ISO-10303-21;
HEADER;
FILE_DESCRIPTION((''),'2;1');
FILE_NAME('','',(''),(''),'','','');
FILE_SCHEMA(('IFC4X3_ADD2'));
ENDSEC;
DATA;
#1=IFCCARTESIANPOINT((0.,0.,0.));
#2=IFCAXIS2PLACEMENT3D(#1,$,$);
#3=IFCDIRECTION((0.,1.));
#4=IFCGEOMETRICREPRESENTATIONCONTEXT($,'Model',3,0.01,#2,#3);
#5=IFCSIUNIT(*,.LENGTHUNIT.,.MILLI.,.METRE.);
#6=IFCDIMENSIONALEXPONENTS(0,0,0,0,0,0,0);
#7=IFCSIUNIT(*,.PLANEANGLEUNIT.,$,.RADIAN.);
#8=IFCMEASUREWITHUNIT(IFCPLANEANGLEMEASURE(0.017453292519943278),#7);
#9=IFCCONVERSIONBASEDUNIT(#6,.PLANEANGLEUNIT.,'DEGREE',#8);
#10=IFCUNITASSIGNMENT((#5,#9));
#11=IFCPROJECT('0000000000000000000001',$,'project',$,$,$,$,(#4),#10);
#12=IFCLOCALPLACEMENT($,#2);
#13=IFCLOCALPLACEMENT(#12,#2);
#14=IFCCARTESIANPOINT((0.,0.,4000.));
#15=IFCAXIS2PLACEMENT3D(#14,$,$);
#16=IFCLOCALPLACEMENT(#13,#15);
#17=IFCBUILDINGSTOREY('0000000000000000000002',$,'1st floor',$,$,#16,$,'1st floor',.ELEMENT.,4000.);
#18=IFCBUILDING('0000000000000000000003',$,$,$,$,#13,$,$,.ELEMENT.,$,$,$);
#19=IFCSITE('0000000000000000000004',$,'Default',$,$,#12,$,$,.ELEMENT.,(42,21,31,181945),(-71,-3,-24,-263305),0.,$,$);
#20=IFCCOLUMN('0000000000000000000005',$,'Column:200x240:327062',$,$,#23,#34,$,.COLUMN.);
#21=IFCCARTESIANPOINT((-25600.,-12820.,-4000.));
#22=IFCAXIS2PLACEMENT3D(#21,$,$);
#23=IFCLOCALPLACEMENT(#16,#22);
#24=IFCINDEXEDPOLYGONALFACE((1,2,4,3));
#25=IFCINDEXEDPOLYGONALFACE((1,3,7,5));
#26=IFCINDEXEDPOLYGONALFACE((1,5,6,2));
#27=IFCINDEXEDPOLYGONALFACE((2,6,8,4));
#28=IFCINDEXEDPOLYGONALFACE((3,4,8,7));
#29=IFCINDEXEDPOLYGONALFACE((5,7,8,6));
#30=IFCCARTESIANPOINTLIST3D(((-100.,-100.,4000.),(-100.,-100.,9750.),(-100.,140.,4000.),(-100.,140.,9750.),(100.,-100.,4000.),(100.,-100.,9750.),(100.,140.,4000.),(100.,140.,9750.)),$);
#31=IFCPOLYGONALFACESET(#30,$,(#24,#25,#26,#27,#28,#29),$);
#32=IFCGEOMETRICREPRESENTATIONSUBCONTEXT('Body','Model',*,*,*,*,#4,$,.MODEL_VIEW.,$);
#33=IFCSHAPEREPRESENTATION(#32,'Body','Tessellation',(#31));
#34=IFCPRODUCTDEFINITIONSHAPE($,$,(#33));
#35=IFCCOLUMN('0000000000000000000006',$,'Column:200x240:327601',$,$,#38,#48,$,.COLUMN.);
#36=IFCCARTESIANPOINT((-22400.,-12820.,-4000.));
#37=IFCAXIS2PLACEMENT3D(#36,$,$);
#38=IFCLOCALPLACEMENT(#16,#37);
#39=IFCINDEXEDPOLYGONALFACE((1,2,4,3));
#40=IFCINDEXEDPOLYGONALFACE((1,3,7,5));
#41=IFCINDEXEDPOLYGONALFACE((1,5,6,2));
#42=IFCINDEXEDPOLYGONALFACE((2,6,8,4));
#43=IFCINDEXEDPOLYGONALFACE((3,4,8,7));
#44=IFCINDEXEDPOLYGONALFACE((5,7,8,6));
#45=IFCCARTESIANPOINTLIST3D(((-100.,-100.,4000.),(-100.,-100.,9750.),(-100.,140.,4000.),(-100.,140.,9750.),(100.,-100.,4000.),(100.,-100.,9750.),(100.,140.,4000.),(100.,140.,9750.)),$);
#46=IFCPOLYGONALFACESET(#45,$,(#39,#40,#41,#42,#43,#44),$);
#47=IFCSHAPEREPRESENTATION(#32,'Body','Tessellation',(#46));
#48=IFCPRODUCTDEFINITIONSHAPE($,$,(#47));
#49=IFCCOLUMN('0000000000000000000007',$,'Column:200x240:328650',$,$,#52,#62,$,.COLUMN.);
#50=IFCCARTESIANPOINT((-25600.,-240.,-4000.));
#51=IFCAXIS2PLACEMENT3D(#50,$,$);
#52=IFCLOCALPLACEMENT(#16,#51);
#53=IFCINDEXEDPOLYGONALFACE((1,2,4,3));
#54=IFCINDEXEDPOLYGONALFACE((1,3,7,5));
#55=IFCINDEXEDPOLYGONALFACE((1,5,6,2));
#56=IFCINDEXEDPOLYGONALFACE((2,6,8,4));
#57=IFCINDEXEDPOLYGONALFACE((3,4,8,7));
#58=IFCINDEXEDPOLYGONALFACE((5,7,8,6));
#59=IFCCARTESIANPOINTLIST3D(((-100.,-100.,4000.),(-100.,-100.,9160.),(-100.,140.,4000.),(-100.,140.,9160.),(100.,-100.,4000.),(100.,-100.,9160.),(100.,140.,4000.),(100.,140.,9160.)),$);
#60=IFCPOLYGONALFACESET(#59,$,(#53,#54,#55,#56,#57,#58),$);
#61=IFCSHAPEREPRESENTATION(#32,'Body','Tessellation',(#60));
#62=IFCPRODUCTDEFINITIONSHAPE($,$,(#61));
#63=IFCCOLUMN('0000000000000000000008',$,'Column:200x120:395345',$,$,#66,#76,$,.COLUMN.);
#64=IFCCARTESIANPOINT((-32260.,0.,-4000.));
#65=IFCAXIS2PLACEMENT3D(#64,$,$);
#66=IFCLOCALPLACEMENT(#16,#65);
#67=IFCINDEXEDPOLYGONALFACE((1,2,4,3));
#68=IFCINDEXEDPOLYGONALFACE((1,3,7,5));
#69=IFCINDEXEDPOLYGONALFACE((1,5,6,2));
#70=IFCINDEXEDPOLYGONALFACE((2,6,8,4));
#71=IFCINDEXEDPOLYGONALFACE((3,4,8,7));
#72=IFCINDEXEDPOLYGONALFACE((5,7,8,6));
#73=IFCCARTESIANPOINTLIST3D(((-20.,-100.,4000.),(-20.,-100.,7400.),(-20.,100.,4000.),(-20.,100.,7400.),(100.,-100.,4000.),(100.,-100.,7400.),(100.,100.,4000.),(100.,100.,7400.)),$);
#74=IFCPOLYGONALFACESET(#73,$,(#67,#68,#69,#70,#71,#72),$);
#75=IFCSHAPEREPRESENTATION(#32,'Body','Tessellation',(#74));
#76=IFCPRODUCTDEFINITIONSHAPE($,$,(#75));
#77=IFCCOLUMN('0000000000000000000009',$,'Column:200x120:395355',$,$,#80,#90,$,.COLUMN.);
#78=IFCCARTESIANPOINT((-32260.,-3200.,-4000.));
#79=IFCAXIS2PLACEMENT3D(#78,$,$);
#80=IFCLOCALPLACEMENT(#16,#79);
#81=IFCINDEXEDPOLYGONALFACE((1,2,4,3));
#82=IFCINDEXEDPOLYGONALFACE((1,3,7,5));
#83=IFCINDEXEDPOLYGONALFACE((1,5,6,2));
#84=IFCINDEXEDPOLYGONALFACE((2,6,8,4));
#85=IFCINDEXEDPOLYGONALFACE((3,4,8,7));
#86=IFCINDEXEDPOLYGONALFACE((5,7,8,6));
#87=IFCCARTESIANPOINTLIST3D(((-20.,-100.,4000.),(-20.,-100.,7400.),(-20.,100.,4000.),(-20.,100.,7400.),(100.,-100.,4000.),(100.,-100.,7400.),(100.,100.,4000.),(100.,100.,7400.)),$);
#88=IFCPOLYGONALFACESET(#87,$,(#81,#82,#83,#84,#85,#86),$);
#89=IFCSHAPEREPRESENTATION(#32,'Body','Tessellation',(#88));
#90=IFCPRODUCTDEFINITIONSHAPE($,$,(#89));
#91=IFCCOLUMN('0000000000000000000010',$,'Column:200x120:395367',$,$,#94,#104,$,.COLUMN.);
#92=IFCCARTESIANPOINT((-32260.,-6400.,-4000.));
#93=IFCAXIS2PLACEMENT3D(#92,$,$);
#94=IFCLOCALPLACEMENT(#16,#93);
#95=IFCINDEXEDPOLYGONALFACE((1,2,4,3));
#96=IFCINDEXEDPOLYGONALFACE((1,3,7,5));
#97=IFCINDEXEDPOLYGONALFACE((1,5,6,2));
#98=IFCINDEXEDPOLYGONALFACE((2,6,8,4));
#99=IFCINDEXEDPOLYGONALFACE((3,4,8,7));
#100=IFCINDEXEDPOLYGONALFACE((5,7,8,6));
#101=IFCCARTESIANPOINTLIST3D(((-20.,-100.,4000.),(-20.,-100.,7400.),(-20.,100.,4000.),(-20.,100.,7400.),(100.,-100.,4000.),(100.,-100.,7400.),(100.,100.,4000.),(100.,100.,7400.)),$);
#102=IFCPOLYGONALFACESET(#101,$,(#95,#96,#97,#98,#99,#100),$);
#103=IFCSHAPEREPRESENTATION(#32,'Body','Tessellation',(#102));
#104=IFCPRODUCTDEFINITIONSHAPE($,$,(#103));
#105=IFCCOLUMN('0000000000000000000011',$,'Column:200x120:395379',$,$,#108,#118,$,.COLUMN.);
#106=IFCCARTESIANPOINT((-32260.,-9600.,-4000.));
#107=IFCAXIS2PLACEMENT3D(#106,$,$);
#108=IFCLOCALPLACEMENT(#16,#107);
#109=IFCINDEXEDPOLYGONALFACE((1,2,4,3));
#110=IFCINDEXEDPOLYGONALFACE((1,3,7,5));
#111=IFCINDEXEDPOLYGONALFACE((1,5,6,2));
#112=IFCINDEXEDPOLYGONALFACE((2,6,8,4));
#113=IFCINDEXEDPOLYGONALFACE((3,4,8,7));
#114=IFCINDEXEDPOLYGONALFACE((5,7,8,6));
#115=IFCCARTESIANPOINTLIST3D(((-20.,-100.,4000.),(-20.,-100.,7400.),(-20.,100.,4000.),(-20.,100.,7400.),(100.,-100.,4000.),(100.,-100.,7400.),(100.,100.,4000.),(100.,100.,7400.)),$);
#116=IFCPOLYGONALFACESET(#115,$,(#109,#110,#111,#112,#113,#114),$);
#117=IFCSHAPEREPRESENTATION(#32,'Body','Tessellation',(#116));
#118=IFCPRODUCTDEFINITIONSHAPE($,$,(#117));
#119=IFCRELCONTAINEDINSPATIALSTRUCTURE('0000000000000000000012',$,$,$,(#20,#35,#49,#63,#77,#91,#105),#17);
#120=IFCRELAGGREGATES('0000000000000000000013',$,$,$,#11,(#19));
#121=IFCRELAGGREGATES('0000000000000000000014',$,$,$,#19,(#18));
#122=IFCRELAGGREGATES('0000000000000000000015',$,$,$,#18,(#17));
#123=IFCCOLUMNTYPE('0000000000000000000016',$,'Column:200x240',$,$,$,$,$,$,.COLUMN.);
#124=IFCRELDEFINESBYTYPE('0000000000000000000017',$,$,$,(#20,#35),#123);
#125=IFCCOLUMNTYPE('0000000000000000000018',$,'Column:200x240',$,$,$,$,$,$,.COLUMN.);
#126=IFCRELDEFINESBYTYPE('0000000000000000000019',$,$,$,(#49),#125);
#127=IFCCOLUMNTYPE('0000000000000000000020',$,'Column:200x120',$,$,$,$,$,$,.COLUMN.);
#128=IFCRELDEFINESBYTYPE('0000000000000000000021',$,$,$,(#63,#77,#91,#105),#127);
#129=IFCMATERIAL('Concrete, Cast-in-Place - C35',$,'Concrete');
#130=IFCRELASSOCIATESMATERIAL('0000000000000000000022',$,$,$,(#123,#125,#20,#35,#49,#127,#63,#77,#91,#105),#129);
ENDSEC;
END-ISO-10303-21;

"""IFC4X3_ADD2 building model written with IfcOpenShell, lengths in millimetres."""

from ifc_helpers import new_model, entity, si_unit, converted_unit, direction, frame, origin, origin_2d_with_axis, place, context, subcontext, project, spatial, rectangle, extrude, source, transform, mapped, material, material_profile, profile_set, profile_usage, type_object, type_shapes, element, save


model = new_model("IFC4X3_ADD2")

# Units and contexts
model_context = context("Model", 3, precision=0.01, world=origin(), true_north=direction((0.0, 1.0)))
body_context = subcontext(model_context, "Body", "Model", "MODEL_VIEW")
ifc_project = project(units=[si_unit("LENGTHUNIT", "METRE", prefix="MILLI"), converted_unit("PLANEANGLEUNIT", "DEGREE", entity("IfcPlaneAngleMeasure", 0.017453292519943278), si_unit("PLANEANGLEUNIT", "RADIAN"), dimensions=[0, 0, 0, 0, 0, 0, 0])], contexts=[model_context])

# Site, building, storey
site_placement = place(None, origin())
site = spatial("IfcSite", under=ifc_project, at=site_placement, Name="Default", CompositionType="ELEMENT", RefLatitude=(42, 21, 31, 181945), RefLongitude=(-71, -3, -24, -263305), RefElevation=0.0)
building_placement = place(site_placement, origin())
building = spatial("IfcBuilding", under=site, at=building_placement, CompositionType="ELEMENT")
storey_placement = place(building_placement, frame((0.0, 0.0, 4000.0)))
storey = spatial("IfcBuildingStorey", under=building, at=storey_placement, Name="1st floor", LongName="1st floor", CompositionType="ELEMENT", Elevation=4000.0)

# Columns
ifc_material_1 = material(Name="Concrete, Cast-in-Place - C35", Category="Concrete")
ifc_material_profile_1 = material_profile(ifc_material_1, rectangle(XDim=200.0, YDim=240.0, at=origin_2d_with_axis()), Name="200x240")
ifc_profile_set_1 = profile_set([ifc_material_profile_1], Name="200x240")
ifc_profile_usage_1 = profile_usage(ifc_profile_set_1)
column_type_1 = type_object("IfcColumnType", Name="Column:200x240", PredefinedType="COLUMN", material=ifc_profile_set_1)
shared_shape_1 = source(origin(), body_context, "Body", "SweptSolid", [
    extrude(rectangle(XDim=200.0, YDim=240.0, at=origin_2d_with_axis()), frame((0.0, 20.0, 4000.0), z_axis=(0.0, 0.0, 1.0), x_axis=(-1.0, 0.0, 0.0)), (0.0, 0.0, 1.0), 5750.0),
])
type_shapes(column_type_1, [shared_shape_1])
for number, where, name in (
    (1, (-25600.0, -12820.0, -4000.0), "Column:200x240:327062"),
    (2, (-22400.0, -12820.0, -4000.0), "Column:200x240:327601"),
):
    element("IfcColumn", number, at=place(storey_placement, frame(where)), inside=storey, type_object=column_type_1, material=ifc_profile_usage_1, Name=name, PredefinedType="COLUMN", context=body_context, shape_type="MappedRepresentation", body=[
        mapped(shared_shape_1, transform((0.0, 0.0, 0.0), scale=1.0)),
    ])
column_type_2 = type_object("IfcColumnType", Name="Column:200x240", PredefinedType="COLUMN", material=ifc_profile_set_1)
shared_shape_2 = source(origin(), body_context, "Body", "SweptSolid", [
    extrude(rectangle(XDim=200.0, YDim=240.0, at=origin_2d_with_axis()), frame((0.0, 20.0, 4000.0), z_axis=(0.0, 0.0, 1.0), x_axis=(-1.0, 0.0, 0.0)), (0.0, 0.0, 1.0), 5160.0),
])
type_shapes(column_type_2, [shared_shape_2])
column_1_placement = place(storey_placement, frame((-25600.0, -240.0, -4000.0)))
element("IfcColumn", 3, at=column_1_placement, inside=storey, type_object=column_type_2, material=ifc_profile_usage_1, Name="Column:200x240:328650", PredefinedType="COLUMN", context=body_context, shape_type="MappedRepresentation", body=[
    mapped(shared_shape_2, transform((0.0, 0.0, 0.0), scale=1.0)),
])
ifc_material_profile_2 = material_profile(ifc_material_1, rectangle(XDim=120.0, YDim=200.0, at=origin_2d_with_axis()), Name="200x120")
ifc_profile_set_2 = profile_set([ifc_material_profile_2], Name="200x120")
ifc_profile_usage_2 = profile_usage(ifc_profile_set_2)
column_type_3 = type_object("IfcColumnType", Name="Column:200x120", PredefinedType="COLUMN", material=ifc_profile_set_2)
shared_shape_3 = source(origin(), body_context, "Body", "SweptSolid", [
    extrude(rectangle(XDim=120.0, YDim=200.0, at=origin_2d_with_axis()), frame((40.0, 0.0, 4000.0), z_axis=(0.0, 0.0, 1.0), x_axis=(-1.0, 0.0, 0.0)), (0.0, 0.0, 1.0), 3400.0),
])
type_shapes(column_type_3, [shared_shape_3])
for number, where, name in (
    (4, (-32260.0, 0.0, -4000.0), "Column:200x120:395345"),
    (5, (-32260.0, -3200.0, -4000.0), "Column:200x120:395355"),
    (6, (-32260.0, -6400.0, -4000.0), "Column:200x120:395367"),
    (7, (-32260.0, -9600.0, -4000.0), "Column:200x120:395379"),
):
    element("IfcColumn", number, at=place(storey_placement, frame(where)), inside=storey, type_object=column_type_3, material=ifc_profile_usage_2, Name=name, PredefinedType="COLUMN", context=body_context, shape_type="MappedRepresentation", body=[
        mapped(shared_shape_3, transform((0.0, 0.0, 0.0), scale=1.0)),
    ])

save(model, "model.ifc")
